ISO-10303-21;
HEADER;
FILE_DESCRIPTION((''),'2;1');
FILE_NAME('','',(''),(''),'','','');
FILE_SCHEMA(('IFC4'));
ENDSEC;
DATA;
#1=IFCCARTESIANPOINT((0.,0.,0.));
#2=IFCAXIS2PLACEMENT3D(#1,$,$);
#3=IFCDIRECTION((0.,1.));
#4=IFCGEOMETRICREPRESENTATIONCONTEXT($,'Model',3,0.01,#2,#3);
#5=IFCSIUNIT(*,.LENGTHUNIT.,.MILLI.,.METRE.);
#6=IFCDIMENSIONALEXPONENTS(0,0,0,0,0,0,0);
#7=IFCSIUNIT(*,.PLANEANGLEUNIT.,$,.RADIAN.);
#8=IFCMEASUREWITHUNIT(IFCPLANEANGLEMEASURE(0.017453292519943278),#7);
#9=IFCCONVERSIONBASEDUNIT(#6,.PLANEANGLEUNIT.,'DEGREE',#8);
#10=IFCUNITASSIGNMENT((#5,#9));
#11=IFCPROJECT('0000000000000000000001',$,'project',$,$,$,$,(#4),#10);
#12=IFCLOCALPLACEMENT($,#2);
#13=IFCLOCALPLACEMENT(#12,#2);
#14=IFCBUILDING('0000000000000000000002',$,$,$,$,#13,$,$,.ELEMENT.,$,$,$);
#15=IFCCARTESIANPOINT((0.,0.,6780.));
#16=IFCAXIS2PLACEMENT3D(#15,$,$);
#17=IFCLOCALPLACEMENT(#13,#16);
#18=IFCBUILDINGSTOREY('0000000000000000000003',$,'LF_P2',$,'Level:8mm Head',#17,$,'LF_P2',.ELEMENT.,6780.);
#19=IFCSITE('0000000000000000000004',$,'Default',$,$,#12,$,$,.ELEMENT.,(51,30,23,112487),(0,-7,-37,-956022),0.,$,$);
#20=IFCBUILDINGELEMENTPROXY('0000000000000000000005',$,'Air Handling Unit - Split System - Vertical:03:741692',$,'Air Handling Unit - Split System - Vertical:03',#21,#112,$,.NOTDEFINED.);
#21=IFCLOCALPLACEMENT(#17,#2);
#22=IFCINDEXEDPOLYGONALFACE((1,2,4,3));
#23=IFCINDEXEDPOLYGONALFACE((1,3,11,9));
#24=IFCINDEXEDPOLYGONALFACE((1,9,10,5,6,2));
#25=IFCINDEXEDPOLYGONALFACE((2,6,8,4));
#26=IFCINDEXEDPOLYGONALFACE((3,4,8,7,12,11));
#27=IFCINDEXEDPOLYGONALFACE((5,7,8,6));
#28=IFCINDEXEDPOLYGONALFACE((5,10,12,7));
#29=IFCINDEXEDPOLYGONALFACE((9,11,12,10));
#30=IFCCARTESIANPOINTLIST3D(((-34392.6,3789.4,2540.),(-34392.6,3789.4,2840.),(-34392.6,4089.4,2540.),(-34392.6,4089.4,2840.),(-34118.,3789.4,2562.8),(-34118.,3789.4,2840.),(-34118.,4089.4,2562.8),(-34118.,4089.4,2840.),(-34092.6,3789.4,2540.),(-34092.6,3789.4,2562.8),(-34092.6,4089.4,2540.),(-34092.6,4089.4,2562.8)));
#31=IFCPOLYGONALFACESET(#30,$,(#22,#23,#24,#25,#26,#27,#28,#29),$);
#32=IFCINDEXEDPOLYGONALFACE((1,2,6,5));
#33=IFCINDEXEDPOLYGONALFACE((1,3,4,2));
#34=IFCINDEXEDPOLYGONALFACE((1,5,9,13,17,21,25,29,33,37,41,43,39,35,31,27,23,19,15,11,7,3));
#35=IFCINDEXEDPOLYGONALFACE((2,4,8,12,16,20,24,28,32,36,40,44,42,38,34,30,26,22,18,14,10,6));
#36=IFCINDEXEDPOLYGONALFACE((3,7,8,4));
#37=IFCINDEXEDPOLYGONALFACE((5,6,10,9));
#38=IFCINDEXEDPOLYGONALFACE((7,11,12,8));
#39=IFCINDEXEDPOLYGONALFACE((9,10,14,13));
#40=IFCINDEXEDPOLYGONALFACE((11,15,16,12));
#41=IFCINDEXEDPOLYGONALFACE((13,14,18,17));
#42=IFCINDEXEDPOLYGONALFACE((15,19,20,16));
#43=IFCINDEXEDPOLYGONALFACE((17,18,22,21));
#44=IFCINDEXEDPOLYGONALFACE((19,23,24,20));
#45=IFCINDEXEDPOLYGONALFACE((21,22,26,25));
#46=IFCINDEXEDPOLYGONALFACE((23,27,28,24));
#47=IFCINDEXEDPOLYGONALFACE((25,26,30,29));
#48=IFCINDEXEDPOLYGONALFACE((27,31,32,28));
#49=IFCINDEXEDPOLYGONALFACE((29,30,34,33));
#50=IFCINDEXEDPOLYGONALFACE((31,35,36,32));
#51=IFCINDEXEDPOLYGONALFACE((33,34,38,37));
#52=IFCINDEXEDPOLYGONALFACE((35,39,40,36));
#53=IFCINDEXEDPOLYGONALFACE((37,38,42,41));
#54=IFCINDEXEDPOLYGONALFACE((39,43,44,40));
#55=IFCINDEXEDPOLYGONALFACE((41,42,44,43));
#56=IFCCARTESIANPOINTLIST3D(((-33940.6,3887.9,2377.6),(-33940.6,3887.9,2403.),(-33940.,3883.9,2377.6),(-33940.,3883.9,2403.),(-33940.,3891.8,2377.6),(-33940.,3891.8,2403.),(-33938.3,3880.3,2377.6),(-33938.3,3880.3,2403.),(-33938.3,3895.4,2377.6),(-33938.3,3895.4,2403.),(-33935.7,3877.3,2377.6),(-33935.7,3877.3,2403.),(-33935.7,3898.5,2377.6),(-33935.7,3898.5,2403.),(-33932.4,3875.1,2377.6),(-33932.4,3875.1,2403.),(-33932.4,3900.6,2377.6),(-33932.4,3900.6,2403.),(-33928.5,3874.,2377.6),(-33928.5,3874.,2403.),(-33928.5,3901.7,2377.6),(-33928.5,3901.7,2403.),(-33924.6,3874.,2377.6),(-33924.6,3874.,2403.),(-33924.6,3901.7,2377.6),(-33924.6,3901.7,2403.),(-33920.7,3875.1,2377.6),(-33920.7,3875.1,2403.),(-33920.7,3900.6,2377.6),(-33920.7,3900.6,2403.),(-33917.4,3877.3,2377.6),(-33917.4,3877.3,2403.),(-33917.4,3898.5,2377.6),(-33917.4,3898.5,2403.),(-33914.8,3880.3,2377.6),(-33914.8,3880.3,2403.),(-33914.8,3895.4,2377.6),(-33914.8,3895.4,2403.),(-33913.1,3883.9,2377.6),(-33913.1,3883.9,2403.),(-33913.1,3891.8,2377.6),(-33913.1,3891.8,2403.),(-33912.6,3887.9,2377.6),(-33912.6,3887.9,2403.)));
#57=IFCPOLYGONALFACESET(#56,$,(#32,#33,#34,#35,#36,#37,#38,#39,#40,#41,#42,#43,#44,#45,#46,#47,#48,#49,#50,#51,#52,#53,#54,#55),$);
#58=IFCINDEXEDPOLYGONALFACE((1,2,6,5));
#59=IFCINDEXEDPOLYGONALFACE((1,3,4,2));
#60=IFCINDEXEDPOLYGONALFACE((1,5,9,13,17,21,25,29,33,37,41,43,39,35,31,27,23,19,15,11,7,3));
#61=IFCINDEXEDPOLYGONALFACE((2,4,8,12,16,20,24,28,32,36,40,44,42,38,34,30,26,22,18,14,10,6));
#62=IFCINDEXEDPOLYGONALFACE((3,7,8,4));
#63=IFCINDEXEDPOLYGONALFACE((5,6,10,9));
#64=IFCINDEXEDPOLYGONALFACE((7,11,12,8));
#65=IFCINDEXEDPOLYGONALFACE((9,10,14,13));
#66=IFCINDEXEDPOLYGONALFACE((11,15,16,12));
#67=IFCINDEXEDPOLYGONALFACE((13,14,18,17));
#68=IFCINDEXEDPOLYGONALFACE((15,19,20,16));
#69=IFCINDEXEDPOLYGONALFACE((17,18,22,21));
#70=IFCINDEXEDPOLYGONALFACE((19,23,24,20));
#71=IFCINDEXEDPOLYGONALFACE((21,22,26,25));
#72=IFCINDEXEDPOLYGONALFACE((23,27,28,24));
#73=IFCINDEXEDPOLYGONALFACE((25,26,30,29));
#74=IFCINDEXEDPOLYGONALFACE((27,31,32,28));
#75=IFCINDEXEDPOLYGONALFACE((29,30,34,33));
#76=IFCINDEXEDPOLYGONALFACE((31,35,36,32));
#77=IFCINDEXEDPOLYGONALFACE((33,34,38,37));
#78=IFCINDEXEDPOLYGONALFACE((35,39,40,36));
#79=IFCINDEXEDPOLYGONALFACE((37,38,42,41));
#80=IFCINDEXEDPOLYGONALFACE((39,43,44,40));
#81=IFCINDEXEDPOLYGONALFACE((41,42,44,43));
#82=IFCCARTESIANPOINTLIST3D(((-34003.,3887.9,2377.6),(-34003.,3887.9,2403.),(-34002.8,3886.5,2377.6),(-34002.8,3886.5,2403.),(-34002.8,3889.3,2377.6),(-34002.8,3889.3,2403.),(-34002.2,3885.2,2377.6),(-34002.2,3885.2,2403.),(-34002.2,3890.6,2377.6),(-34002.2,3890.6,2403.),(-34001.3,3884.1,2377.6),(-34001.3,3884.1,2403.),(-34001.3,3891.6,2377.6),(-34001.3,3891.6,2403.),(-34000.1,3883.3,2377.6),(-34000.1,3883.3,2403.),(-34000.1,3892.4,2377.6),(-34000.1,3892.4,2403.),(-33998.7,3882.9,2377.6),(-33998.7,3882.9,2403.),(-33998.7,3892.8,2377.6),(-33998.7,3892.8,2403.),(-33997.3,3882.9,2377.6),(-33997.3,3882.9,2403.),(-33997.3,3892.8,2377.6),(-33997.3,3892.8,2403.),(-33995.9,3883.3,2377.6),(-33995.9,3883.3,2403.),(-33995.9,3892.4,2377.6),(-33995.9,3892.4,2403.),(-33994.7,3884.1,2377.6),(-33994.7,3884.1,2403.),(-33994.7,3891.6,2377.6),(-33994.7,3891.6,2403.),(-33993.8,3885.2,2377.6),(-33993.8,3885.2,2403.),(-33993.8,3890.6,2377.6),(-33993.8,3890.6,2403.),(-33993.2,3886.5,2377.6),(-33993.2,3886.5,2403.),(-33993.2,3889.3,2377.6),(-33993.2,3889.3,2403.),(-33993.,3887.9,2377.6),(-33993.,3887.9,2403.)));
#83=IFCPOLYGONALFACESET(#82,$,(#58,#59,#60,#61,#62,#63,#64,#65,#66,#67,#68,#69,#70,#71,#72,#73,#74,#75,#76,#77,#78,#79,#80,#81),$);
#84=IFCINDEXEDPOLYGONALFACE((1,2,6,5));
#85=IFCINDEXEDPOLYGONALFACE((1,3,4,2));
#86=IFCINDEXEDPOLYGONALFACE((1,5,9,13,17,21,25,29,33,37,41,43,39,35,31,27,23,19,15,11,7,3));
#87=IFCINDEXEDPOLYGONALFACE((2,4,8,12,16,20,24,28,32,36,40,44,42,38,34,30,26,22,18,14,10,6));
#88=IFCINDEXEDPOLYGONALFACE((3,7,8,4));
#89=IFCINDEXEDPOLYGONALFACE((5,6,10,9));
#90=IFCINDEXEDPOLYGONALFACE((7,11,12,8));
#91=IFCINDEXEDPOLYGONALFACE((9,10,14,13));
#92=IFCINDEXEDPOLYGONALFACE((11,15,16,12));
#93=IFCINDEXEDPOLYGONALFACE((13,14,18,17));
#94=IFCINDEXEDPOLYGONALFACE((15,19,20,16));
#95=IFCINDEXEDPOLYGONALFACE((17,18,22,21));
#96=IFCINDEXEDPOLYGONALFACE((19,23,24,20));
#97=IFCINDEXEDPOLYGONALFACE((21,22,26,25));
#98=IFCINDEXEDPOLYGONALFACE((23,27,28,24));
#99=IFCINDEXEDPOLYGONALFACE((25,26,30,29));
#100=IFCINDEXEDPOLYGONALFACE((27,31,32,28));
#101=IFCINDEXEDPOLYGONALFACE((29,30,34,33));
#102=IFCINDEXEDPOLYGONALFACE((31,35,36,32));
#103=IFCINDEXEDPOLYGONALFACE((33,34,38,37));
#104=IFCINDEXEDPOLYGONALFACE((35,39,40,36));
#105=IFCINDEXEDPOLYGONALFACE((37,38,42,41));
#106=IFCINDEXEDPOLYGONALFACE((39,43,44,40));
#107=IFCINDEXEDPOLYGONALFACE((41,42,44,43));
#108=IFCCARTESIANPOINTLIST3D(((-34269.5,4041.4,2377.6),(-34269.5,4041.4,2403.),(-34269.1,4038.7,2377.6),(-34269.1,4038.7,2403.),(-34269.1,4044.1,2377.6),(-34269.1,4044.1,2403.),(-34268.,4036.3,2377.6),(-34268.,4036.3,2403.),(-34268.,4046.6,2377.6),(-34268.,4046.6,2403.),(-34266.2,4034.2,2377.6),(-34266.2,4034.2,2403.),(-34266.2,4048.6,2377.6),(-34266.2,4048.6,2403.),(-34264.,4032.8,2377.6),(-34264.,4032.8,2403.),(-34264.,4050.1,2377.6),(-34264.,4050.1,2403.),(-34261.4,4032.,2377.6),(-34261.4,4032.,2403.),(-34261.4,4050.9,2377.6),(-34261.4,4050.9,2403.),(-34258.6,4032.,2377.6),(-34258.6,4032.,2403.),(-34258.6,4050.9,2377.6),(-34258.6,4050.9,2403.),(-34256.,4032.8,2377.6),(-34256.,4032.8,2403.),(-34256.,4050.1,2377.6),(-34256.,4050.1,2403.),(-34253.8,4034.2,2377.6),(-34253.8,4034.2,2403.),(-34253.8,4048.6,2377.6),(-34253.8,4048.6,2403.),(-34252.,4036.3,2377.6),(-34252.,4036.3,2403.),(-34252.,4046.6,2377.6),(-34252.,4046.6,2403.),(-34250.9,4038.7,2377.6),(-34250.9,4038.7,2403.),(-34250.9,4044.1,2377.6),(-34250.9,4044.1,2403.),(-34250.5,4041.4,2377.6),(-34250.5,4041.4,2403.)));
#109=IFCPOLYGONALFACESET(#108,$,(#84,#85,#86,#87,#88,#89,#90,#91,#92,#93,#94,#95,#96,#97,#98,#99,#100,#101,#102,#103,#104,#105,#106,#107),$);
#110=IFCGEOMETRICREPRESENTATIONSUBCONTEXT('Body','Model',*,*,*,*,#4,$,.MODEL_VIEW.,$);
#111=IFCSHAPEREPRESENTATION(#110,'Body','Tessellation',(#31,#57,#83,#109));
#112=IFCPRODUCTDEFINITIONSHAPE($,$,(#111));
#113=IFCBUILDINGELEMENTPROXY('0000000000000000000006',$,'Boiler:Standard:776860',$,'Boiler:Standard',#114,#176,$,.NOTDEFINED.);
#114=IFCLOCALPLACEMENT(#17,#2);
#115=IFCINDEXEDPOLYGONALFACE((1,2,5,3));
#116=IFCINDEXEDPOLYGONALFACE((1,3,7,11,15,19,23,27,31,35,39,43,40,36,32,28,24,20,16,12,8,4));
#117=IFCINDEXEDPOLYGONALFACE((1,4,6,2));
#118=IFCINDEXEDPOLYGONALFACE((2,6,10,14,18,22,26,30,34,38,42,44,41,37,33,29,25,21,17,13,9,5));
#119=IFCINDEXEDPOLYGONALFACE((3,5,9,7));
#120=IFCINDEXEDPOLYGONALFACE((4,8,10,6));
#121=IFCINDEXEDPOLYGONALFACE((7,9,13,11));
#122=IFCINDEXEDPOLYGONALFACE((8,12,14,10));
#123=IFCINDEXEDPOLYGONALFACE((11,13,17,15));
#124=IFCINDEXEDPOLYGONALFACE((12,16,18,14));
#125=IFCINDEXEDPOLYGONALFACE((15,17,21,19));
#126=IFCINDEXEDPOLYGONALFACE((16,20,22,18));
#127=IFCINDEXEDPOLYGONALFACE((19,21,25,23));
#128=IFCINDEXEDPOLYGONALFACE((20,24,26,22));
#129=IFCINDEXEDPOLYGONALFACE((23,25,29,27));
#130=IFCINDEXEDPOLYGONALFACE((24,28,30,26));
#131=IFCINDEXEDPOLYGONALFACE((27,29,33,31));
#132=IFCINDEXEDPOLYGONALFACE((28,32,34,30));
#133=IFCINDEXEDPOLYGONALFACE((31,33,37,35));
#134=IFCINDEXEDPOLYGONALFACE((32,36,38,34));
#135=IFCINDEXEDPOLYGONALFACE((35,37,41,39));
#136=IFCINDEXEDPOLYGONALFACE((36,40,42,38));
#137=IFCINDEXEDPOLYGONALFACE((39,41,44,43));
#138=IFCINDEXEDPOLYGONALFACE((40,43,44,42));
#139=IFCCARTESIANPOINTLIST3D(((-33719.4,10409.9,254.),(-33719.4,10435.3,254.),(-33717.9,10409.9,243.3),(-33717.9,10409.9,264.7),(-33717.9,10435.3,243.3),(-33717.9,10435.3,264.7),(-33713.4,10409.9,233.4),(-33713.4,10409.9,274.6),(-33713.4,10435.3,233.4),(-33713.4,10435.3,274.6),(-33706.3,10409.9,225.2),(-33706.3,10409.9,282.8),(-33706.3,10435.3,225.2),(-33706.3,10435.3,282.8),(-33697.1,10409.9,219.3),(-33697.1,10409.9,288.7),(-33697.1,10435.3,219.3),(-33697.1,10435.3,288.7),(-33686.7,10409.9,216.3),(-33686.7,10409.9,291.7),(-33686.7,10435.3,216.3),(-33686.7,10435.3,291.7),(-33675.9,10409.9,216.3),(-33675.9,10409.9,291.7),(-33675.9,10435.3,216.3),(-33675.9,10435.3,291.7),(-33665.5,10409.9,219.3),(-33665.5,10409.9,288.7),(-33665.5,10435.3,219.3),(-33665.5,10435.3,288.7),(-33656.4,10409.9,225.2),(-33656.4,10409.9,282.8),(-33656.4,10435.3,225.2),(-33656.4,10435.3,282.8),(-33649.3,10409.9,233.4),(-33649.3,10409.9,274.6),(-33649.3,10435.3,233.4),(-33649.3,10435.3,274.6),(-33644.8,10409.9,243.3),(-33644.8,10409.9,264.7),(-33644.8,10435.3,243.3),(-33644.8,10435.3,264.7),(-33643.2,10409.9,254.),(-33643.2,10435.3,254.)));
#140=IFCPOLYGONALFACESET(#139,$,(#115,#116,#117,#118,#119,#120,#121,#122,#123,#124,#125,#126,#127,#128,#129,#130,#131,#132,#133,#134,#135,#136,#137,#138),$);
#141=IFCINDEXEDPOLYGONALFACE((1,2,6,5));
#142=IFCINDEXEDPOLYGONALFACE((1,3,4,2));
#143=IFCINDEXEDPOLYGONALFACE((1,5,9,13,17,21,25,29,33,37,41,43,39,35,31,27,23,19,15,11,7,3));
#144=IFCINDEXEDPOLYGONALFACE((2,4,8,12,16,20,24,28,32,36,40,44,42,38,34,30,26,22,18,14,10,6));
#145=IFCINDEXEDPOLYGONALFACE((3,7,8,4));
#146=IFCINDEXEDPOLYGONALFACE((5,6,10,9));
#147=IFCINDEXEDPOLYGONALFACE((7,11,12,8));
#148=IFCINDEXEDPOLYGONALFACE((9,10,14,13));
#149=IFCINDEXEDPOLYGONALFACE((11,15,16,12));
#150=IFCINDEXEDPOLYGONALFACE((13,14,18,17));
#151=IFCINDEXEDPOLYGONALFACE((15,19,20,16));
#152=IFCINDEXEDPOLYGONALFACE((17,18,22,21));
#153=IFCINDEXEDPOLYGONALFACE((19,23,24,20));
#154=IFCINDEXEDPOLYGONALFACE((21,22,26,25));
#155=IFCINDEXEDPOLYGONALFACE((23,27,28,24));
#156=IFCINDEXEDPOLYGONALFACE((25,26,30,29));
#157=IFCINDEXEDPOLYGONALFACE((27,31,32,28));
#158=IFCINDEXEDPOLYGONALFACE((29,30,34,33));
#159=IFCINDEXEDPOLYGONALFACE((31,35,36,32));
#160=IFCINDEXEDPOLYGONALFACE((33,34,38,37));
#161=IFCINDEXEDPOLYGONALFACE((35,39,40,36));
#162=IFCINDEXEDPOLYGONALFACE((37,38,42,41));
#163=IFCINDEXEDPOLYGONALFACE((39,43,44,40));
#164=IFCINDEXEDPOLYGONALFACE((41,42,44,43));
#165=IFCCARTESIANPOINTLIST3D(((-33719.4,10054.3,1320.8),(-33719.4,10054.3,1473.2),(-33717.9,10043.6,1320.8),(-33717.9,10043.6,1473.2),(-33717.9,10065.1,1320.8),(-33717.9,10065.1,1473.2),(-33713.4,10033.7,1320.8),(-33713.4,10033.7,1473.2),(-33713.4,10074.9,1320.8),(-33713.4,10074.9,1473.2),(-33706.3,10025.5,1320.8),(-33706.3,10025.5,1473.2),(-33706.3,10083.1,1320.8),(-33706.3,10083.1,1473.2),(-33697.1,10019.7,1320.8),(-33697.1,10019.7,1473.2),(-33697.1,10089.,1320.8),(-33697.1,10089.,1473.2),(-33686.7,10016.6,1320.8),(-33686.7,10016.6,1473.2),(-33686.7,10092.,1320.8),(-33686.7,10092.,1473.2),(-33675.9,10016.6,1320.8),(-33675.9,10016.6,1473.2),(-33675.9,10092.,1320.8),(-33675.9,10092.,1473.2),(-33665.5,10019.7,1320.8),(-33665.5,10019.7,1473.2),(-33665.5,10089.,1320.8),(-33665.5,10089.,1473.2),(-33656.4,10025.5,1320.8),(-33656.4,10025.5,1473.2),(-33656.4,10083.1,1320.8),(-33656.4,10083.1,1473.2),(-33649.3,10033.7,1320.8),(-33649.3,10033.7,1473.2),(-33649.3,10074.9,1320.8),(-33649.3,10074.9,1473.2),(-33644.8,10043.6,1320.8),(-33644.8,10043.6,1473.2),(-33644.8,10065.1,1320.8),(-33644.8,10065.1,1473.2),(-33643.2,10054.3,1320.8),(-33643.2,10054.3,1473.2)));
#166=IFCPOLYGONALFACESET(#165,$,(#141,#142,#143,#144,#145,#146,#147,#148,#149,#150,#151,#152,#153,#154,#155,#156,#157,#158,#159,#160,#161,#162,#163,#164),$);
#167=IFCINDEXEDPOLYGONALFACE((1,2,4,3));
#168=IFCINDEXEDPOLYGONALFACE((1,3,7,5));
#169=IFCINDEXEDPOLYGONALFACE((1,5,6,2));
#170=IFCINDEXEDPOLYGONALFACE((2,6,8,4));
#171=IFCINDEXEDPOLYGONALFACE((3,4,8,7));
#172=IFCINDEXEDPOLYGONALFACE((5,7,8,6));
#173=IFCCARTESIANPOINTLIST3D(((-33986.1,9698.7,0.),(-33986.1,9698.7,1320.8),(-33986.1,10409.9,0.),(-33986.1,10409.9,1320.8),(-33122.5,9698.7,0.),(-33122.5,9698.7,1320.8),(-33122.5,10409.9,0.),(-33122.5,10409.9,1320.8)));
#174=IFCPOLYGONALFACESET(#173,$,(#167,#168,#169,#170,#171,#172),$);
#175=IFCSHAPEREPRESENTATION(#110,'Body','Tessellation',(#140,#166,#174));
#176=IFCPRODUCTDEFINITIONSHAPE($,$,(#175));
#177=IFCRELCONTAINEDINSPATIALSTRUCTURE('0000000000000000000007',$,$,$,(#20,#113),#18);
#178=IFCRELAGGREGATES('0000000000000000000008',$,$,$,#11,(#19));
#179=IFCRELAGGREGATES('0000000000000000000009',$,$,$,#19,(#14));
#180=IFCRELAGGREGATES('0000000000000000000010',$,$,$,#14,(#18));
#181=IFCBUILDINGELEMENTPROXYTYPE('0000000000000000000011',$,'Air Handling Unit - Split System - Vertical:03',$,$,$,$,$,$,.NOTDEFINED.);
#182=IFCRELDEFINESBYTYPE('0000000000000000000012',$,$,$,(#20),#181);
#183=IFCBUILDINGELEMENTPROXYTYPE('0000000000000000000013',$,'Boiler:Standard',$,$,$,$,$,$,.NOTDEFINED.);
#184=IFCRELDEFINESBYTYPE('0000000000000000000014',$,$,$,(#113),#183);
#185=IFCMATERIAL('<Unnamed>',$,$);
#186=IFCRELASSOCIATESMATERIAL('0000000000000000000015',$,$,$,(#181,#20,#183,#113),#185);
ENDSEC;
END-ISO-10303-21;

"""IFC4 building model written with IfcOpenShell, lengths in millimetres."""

from ifc_helpers import new_model, entity, si_unit, converted_unit, direction, frame, origin, place, context, subcontext, project, spatial, arc, indexed_curve, outline, extrude, source, transform, mapped, material, type_object, type_shapes, element, save


model = new_model("IFC4")

# Units and contexts
model_context = context("Model", 3, precision=0.01, world=origin(), true_north=direction((0.0, 1.0)))
body_context = subcontext(model_context, "Body", "Model", "MODEL_VIEW")
ifc_project = project(units=[si_unit("LENGTHUNIT", "METRE", prefix="MILLI"), converted_unit("PLANEANGLEUNIT", "DEGREE", entity("IfcPlaneAngleMeasure", 0.017453292519943278), si_unit("PLANEANGLEUNIT", "RADIAN"), dimensions=[0, 0, 0, 0, 0, 0, 0])], contexts=[model_context])

# Site, building, storey
site_placement = place(None, origin())
site = spatial("IfcSite", under=ifc_project, at=site_placement, Name="Default", CompositionType="ELEMENT", RefLatitude=(51, 30, 23, 112487), RefLongitude=(0, -7, -37, -956022), RefElevation=0.0)
building_placement = place(site_placement, origin())
building = spatial("IfcBuilding", under=site, at=building_placement, CompositionType="ELEMENT")
storey_placement = place(building_placement, frame((0.0, 0.0, 6780.0)))
storey = spatial("IfcBuildingStorey", under=building, at=storey_placement, Name="LF_P2", ObjectType="Level:8mm Head", LongName="LF_P2", CompositionType="ELEMENT", Elevation=6780.0)

# Shared definitions
ifc_material = material(Name="<Unnamed>")

# Building element proxies
building_element_proxy_type_1 = type_object("IfcBuildingElementProxyType", Name="Air Handling Unit - Split System - Vertical:03", PredefinedType="NOTDEFINED", material=ifc_material)
shared_shape_1 = source(origin(), body_context, "Body", "SweptSolid", [
    extrude(outline(indexed_curve([(-191.5, -107.6), (108.5, -107.6), (108.5, -84.8), (83.1, -84.8), (83.1, 192.4), (-191.5, 192.4), (-191.5, -107.6)], self_intersect=False)), frame((-150.0, 42.4, 191.5), z_axis=(1.0, 0.0, 0.0), x_axis=(0.0, 0.0, 1.0)), (0.0, 0.0, 1.0), 300.0),
    extrude(outline(indexed_curve([(-14.0, 0.0), (0.0, -14.0), (14.0, 0.0), (0.0, 14.0)], segments=[arc(1, 2, 3), arc(3, 4, 1)], self_intersect=False)), frame((51.6, 287.0, 466.0), z_axis=(0.0, 1.0, 0.0), x_axis=(0.0, 0.0, -1.0)), (0.0, 0.0, 1.0), 25.4),
    extrude(outline(indexed_curve([(-5.0, 0.0), (0.0, -5.0), (5.0, 0.0), (0.0, 5.0)], segments=[arc(1, 2, 3), arc(3, 4, 1)], self_intersect=False)), frame((51.6, 287.0, 394.6), z_axis=(0.0, 1.0, 0.0), x_axis=(0.0, 0.0, -1.0)), (0.0, 0.0, 1.0), 25.4),
    extrude(outline(indexed_curve([(-9.5, 0.0), (0.0, -9.5), (9.5, 0.0), (0.0, 9.5)], segments=[arc(1, 2, 3), arc(3, 4, 1)], self_intersect=False)), frame((-102.0, 287.0, 132.6), z_axis=(0.0, 1.0, 0.0), x_axis=(0.0, 0.0, -1.0)), (0.0, 0.0, 1.0), 25.4),
])
type_shapes(building_element_proxy_type_1, [shared_shape_1])
for number, where, z_axis, x_axis, name in (
    (1, (-34392.6, 3939.4, 2690.0), (1.0, 0.0, 0.0), (0.0, -1.0, 0.0), "Air Handling Unit - Split System - Vertical:03:741692"),
):
    element("IfcBuildingElementProxy", number, at=place(storey_placement, frame(where, z_axis=z_axis, x_axis=x_axis)), inside=storey, type_object=building_element_proxy_type_1, material=ifc_material, Name=name, ObjectType="Air Handling Unit - Split System - Vertical:03", PredefinedType="NOTDEFINED", context=body_context, shape_type="MappedRepresentation", body=[
        mapped(shared_shape_1, transform((0.0, 0.0, 0.0), scale=1.0)),
    ])
building_element_proxy_type_2 = type_object("IfcBuildingElementProxyType", Name="Boiler:Standard", PredefinedType="NOTDEFINED", material=ifc_material)
shared_shape_2 = source(origin(), body_context, "Body", "SweptSolid", [
    extrude(outline(indexed_curve([(-38.1, 0.0), (0.0, -38.1), (38.1, 0.0), (0.0, 38.1)], segments=[arc(1, 2, 3), arc(3, 4, 1)], self_intersect=False)), frame((304.8, 711.2, 254.0), z_axis=(0.0, 1.0, 0.0), x_axis=(-1.0, 0.0, 0.0)), (0.0, 0.0, 1.0), 25.4),
    extrude(outline(indexed_curve([(-38.1, 0.0), (0.0, -38.1), (38.1, 0.0), (0.0, 38.1)], segments=[arc(1, 2, 3), arc(3, 4, 1)], self_intersect=False)), frame((304.8, 355.6, 1320.8)), (0.0, 0.0, 1.0), 152.4),
    extrude(outline(indexed_curve([(-355.6, -431.8), (355.6, -431.8), (355.6, 431.8), (-355.6, 431.8), (-355.6, -431.8)], self_intersect=False)), frame((431.8, 355.6, 0.0), z_axis=(0.0, 0.0, 1.0), x_axis=(0.0, 1.0, 0.0)), (0.0, 0.0, 1.0), 1320.8),
])
type_shapes(building_element_proxy_type_2, [shared_shape_2])
proxy_placement = place(storey_placement, frame((-33986.1, 9698.7, 0.0)))
element("IfcBuildingElementProxy", 2, at=proxy_placement, inside=storey, type_object=building_element_proxy_type_2, material=ifc_material, Name="Boiler:Standard:776860", ObjectType="Boiler:Standard", PredefinedType="NOTDEFINED", context=body_context, shape_type="MappedRepresentation", body=[
    mapped(shared_shape_2, transform((0.0, 0.0, 0.0), scale=1.0)),
])

save(model, "model.ifc")
